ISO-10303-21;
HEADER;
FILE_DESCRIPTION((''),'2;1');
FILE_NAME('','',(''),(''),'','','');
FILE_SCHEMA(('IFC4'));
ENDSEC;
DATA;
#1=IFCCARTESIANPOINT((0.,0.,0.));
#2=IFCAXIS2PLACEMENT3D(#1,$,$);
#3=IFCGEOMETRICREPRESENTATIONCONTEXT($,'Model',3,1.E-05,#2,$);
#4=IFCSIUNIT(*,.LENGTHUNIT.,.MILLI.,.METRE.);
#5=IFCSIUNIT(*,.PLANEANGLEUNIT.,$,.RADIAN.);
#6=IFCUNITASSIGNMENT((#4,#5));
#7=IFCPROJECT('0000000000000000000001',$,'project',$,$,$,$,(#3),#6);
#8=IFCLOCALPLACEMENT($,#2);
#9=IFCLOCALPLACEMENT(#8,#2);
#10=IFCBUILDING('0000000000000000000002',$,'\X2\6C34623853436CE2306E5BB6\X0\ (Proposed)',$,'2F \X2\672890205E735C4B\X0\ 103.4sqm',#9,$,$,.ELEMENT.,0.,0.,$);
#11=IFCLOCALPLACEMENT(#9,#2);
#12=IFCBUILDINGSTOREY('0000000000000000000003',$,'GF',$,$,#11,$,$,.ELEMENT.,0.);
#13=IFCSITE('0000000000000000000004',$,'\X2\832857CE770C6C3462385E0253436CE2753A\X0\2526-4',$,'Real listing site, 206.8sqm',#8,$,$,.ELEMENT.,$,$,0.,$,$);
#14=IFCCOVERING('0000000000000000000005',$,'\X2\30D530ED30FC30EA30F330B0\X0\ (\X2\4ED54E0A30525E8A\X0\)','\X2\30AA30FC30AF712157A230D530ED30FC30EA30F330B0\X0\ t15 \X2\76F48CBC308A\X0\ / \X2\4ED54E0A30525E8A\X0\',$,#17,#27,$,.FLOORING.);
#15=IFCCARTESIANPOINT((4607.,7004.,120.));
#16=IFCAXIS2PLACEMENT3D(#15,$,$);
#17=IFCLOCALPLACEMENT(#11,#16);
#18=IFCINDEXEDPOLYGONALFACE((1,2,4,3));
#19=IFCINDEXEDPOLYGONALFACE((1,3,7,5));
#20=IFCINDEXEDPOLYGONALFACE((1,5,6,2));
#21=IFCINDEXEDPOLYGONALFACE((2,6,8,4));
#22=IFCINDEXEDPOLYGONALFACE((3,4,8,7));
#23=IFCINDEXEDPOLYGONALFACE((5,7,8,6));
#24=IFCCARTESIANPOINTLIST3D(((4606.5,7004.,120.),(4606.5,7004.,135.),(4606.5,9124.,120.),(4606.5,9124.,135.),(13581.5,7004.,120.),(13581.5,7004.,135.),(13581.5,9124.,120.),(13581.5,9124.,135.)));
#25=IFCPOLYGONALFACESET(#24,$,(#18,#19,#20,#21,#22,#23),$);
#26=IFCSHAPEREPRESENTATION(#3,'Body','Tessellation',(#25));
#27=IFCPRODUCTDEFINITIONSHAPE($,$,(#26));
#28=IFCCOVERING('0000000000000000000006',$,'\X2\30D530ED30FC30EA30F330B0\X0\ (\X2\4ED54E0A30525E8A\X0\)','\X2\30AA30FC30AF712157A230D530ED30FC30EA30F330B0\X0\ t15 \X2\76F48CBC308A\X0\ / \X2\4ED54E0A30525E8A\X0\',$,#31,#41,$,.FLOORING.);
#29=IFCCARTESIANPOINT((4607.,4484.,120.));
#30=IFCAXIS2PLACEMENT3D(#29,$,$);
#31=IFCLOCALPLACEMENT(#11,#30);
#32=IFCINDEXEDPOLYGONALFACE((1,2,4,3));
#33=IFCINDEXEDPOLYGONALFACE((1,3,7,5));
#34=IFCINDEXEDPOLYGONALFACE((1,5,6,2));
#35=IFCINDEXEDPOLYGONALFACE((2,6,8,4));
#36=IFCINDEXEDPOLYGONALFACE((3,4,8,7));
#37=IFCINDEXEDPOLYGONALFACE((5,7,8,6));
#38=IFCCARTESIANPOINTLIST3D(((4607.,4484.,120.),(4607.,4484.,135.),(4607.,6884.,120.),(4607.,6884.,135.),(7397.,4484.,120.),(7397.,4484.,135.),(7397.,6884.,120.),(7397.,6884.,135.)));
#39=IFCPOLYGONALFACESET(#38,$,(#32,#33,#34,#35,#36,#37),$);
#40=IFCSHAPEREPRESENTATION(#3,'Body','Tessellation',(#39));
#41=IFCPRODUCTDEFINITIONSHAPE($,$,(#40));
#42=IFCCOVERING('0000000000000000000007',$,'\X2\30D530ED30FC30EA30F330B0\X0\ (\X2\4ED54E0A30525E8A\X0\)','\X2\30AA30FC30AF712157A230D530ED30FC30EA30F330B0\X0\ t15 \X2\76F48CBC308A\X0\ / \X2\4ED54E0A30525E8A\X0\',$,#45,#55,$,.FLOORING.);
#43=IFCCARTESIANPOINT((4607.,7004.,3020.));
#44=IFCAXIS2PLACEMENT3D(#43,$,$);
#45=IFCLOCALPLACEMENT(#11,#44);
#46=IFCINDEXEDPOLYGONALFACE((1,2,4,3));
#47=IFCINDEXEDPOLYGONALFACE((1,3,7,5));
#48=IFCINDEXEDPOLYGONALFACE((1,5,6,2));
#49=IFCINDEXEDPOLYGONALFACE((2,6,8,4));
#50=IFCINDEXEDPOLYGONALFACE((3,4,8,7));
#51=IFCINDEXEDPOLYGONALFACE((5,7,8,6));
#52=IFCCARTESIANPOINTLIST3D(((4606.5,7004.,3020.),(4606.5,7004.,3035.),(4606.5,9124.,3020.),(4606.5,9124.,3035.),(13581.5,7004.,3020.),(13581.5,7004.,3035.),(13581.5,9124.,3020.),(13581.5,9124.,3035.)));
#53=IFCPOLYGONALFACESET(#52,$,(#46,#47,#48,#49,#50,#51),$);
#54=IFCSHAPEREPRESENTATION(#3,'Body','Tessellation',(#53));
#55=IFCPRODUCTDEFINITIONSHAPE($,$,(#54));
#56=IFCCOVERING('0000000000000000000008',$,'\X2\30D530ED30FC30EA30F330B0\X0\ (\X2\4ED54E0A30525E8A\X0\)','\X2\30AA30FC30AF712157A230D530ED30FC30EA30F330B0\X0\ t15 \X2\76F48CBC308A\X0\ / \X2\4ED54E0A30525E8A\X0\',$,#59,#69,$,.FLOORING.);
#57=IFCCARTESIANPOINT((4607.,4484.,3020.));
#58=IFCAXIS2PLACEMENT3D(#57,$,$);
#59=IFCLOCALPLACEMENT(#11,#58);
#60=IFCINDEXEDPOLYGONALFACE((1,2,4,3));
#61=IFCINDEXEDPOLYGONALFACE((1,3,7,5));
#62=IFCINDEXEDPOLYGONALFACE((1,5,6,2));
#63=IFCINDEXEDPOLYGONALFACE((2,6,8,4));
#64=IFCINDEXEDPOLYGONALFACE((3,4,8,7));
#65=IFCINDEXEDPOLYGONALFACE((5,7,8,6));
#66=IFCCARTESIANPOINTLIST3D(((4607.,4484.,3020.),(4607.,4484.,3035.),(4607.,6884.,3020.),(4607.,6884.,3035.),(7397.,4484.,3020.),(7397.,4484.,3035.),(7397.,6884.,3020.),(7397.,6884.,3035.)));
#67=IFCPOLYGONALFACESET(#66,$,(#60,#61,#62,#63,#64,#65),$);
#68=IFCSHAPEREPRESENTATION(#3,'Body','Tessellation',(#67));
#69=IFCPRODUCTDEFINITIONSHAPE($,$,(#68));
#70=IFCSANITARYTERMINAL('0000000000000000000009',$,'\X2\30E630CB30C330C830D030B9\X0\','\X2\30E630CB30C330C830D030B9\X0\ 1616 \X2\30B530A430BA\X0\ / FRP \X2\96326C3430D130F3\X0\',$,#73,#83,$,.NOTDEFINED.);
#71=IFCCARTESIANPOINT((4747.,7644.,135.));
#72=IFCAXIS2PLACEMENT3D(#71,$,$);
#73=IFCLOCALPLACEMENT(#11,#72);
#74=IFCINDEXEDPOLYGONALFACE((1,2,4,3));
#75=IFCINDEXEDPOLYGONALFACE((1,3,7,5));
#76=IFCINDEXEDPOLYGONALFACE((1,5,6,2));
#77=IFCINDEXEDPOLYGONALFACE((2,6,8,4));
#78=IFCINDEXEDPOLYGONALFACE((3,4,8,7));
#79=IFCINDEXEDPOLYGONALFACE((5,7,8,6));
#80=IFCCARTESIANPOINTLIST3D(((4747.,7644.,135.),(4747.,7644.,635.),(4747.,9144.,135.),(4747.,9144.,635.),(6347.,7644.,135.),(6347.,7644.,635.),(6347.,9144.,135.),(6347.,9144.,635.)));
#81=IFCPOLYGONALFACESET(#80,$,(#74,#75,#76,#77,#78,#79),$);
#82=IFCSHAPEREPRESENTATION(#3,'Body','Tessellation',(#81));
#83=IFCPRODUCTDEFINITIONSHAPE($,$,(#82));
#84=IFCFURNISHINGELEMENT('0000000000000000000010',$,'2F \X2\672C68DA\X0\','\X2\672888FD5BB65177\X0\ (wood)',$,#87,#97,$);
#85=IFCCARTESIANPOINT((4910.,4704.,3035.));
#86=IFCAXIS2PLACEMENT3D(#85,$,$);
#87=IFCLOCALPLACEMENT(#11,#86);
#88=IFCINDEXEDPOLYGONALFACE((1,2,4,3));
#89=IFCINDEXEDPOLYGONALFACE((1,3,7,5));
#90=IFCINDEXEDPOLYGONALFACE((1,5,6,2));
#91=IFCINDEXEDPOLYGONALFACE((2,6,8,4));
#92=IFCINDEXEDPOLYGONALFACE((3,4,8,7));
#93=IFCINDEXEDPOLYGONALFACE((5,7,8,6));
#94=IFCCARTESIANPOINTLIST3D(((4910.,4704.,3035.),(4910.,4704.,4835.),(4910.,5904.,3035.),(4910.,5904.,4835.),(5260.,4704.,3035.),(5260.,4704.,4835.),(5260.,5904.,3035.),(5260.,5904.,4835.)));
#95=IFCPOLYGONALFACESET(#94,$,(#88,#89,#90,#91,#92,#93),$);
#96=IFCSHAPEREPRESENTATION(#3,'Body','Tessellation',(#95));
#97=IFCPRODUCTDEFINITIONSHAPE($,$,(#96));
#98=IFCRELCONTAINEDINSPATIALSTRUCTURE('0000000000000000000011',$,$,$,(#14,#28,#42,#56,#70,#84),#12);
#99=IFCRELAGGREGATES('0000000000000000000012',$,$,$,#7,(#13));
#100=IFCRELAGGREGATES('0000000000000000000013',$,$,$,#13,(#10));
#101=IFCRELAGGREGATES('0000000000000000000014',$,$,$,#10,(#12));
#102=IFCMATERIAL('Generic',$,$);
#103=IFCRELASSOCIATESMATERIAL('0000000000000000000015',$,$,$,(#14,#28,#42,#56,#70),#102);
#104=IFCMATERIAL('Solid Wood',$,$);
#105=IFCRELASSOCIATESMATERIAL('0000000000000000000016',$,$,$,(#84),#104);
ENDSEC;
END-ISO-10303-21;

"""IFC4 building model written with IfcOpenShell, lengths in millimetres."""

from ifc_helpers import new_model, si_unit, frame, frame_2d, origin, place, context, project, spatial, rectangle, extrude, material, element, save


model = new_model("IFC4")

# Units and contexts
model_context = context("Model", 3, precision=1e-05, world=origin())
ifc_project = project(units=[si_unit("LENGTHUNIT", "METRE", prefix="MILLI"), si_unit("PLANEANGLEUNIT", "RADIAN")], contexts=[model_context])

# Site, building, storey
site_placement = place(None, origin())
site = spatial("IfcSite", under=ifc_project, at=site_placement, Name="茨城県水戸市千波町2526-4", ObjectType="Real listing site, 206.8sqm", CompositionType="ELEMENT", RefElevation=0.0)
building_placement = place(site_placement, origin())
building = spatial("IfcBuilding", under=site, at=building_placement, Name="水戸千波の家 (Proposed)", ObjectType="2F 木造平屋 103.4sqm", CompositionType="ELEMENT", ElevationOfRefHeight=0.0, ElevationOfTerrain=0.0)
storey_placement = place(building_placement, origin())
storey = spatial("IfcBuildingStorey", under=building, at=storey_placement, Name="GF", CompositionType="ELEMENT", Elevation=0.0)

# Shared definitions
ifc_material_1 = material(Name="Solid Wood")

# Coverings
ifc_material_2 = material(Name="Generic")
covering_1_placement = place(storey_placement, frame((4607.0, 7004.0, 120.0)))
element("IfcCovering", 1, at=covering_1_placement, inside=storey, material=ifc_material_2, Name="フローリング (仕上げ床)", Description="オーク無垢フローリング t15 直貼り / 仕上げ床", PredefinedType="FLOORING", context=model_context, shape_type="SweptSolid", body=[
    extrude(rectangle(XDim=8975.0, YDim=2120.0, at=frame_2d((4487.0, 1060.0))), frame((4607.0, 7004.0, 120.0)), (0.0, 0.0, 1.0), 15.0),
])
covering_2_placement = place(storey_placement, frame((4607.0, 4484.0, 120.0)))
element("IfcCovering", 2, at=covering_2_placement, inside=storey, material=ifc_material_2, Name="フローリング (仕上げ床)", Description="オーク無垢フローリング t15 直貼り / 仕上げ床", PredefinedType="FLOORING", context=model_context, shape_type="SweptSolid", body=[
    extrude(rectangle(XDim=2790.0, YDim=2400.0, at=frame_2d((1395.0, 1200.0))), frame((4607.0, 4484.0, 120.0)), (0.0, 0.0, 1.0), 15.0),
])
covering_3_placement = place(storey_placement, frame((4607.0, 7004.0, 3020.0)))
element("IfcCovering", 3, at=covering_3_placement, inside=storey, material=ifc_material_2, Name="フローリング (仕上げ床)", Description="オーク無垢フローリング t15 直貼り / 仕上げ床", PredefinedType="FLOORING", context=model_context, shape_type="SweptSolid", body=[
    extrude(rectangle(XDim=8975.0, YDim=2120.0, at=frame_2d((4487.0, 1060.0))), frame((4607.0, 7004.0, 3020.0)), (0.0, 0.0, 1.0), 15.0),
])
covering_4_placement = place(storey_placement, frame((4607.0, 4484.0, 3020.0)))
element("IfcCovering", 4, at=covering_4_placement, inside=storey, material=ifc_material_2, Name="フローリング (仕上げ床)", Description="オーク無垢フローリング t15 直貼り / 仕上げ床", PredefinedType="FLOORING", context=model_context, shape_type="SweptSolid", body=[
    extrude(rectangle(XDim=2790.0, YDim=2400.0, at=frame_2d((1395.0, 1200.0))), frame((4607.0, 4484.0, 3020.0)), (0.0, 0.0, 1.0), 15.0),
])

# Sanitary terminal
sanitary_terminal_placement = place(storey_placement, frame((4747.0, 7644.0, 135.0)))
element("IfcSanitaryTerminal", 5, at=sanitary_terminal_placement, inside=storey, material=ifc_material_2, Name="ユニットバス", Description="ユニットバス 1616 サイズ / FRP 防水パン", PredefinedType="NOTDEFINED", context=model_context, shape_type="SweptSolid", body=[
    extrude(rectangle(XDim=1600.0, YDim=1500.0, at=frame_2d((800.0, 750.0))), frame((4747.0, 7644.0, 135.0)), (0.0, 0.0, 1.0), 500.0),
])

# Furnishing element
furnishing_placement = place(storey_placement, frame((4910.0, 4704.0, 3035.0)))
element("IfcFurnishingElement", 6, at=furnishing_placement, inside=storey, material=ifc_material_1, Name="2F 本棚", Description="木製家具 (wood)", context=model_context, shape_type="SweptSolid", body=[
    extrude(rectangle(XDim=350.0, YDim=1200.0, at=frame_2d((175.0, 600.0))), frame((4910.0, 4704.0, 3035.0)), (0.0, 0.0, 1.0), 1800.0),
])

save(model, "model.ifc")
